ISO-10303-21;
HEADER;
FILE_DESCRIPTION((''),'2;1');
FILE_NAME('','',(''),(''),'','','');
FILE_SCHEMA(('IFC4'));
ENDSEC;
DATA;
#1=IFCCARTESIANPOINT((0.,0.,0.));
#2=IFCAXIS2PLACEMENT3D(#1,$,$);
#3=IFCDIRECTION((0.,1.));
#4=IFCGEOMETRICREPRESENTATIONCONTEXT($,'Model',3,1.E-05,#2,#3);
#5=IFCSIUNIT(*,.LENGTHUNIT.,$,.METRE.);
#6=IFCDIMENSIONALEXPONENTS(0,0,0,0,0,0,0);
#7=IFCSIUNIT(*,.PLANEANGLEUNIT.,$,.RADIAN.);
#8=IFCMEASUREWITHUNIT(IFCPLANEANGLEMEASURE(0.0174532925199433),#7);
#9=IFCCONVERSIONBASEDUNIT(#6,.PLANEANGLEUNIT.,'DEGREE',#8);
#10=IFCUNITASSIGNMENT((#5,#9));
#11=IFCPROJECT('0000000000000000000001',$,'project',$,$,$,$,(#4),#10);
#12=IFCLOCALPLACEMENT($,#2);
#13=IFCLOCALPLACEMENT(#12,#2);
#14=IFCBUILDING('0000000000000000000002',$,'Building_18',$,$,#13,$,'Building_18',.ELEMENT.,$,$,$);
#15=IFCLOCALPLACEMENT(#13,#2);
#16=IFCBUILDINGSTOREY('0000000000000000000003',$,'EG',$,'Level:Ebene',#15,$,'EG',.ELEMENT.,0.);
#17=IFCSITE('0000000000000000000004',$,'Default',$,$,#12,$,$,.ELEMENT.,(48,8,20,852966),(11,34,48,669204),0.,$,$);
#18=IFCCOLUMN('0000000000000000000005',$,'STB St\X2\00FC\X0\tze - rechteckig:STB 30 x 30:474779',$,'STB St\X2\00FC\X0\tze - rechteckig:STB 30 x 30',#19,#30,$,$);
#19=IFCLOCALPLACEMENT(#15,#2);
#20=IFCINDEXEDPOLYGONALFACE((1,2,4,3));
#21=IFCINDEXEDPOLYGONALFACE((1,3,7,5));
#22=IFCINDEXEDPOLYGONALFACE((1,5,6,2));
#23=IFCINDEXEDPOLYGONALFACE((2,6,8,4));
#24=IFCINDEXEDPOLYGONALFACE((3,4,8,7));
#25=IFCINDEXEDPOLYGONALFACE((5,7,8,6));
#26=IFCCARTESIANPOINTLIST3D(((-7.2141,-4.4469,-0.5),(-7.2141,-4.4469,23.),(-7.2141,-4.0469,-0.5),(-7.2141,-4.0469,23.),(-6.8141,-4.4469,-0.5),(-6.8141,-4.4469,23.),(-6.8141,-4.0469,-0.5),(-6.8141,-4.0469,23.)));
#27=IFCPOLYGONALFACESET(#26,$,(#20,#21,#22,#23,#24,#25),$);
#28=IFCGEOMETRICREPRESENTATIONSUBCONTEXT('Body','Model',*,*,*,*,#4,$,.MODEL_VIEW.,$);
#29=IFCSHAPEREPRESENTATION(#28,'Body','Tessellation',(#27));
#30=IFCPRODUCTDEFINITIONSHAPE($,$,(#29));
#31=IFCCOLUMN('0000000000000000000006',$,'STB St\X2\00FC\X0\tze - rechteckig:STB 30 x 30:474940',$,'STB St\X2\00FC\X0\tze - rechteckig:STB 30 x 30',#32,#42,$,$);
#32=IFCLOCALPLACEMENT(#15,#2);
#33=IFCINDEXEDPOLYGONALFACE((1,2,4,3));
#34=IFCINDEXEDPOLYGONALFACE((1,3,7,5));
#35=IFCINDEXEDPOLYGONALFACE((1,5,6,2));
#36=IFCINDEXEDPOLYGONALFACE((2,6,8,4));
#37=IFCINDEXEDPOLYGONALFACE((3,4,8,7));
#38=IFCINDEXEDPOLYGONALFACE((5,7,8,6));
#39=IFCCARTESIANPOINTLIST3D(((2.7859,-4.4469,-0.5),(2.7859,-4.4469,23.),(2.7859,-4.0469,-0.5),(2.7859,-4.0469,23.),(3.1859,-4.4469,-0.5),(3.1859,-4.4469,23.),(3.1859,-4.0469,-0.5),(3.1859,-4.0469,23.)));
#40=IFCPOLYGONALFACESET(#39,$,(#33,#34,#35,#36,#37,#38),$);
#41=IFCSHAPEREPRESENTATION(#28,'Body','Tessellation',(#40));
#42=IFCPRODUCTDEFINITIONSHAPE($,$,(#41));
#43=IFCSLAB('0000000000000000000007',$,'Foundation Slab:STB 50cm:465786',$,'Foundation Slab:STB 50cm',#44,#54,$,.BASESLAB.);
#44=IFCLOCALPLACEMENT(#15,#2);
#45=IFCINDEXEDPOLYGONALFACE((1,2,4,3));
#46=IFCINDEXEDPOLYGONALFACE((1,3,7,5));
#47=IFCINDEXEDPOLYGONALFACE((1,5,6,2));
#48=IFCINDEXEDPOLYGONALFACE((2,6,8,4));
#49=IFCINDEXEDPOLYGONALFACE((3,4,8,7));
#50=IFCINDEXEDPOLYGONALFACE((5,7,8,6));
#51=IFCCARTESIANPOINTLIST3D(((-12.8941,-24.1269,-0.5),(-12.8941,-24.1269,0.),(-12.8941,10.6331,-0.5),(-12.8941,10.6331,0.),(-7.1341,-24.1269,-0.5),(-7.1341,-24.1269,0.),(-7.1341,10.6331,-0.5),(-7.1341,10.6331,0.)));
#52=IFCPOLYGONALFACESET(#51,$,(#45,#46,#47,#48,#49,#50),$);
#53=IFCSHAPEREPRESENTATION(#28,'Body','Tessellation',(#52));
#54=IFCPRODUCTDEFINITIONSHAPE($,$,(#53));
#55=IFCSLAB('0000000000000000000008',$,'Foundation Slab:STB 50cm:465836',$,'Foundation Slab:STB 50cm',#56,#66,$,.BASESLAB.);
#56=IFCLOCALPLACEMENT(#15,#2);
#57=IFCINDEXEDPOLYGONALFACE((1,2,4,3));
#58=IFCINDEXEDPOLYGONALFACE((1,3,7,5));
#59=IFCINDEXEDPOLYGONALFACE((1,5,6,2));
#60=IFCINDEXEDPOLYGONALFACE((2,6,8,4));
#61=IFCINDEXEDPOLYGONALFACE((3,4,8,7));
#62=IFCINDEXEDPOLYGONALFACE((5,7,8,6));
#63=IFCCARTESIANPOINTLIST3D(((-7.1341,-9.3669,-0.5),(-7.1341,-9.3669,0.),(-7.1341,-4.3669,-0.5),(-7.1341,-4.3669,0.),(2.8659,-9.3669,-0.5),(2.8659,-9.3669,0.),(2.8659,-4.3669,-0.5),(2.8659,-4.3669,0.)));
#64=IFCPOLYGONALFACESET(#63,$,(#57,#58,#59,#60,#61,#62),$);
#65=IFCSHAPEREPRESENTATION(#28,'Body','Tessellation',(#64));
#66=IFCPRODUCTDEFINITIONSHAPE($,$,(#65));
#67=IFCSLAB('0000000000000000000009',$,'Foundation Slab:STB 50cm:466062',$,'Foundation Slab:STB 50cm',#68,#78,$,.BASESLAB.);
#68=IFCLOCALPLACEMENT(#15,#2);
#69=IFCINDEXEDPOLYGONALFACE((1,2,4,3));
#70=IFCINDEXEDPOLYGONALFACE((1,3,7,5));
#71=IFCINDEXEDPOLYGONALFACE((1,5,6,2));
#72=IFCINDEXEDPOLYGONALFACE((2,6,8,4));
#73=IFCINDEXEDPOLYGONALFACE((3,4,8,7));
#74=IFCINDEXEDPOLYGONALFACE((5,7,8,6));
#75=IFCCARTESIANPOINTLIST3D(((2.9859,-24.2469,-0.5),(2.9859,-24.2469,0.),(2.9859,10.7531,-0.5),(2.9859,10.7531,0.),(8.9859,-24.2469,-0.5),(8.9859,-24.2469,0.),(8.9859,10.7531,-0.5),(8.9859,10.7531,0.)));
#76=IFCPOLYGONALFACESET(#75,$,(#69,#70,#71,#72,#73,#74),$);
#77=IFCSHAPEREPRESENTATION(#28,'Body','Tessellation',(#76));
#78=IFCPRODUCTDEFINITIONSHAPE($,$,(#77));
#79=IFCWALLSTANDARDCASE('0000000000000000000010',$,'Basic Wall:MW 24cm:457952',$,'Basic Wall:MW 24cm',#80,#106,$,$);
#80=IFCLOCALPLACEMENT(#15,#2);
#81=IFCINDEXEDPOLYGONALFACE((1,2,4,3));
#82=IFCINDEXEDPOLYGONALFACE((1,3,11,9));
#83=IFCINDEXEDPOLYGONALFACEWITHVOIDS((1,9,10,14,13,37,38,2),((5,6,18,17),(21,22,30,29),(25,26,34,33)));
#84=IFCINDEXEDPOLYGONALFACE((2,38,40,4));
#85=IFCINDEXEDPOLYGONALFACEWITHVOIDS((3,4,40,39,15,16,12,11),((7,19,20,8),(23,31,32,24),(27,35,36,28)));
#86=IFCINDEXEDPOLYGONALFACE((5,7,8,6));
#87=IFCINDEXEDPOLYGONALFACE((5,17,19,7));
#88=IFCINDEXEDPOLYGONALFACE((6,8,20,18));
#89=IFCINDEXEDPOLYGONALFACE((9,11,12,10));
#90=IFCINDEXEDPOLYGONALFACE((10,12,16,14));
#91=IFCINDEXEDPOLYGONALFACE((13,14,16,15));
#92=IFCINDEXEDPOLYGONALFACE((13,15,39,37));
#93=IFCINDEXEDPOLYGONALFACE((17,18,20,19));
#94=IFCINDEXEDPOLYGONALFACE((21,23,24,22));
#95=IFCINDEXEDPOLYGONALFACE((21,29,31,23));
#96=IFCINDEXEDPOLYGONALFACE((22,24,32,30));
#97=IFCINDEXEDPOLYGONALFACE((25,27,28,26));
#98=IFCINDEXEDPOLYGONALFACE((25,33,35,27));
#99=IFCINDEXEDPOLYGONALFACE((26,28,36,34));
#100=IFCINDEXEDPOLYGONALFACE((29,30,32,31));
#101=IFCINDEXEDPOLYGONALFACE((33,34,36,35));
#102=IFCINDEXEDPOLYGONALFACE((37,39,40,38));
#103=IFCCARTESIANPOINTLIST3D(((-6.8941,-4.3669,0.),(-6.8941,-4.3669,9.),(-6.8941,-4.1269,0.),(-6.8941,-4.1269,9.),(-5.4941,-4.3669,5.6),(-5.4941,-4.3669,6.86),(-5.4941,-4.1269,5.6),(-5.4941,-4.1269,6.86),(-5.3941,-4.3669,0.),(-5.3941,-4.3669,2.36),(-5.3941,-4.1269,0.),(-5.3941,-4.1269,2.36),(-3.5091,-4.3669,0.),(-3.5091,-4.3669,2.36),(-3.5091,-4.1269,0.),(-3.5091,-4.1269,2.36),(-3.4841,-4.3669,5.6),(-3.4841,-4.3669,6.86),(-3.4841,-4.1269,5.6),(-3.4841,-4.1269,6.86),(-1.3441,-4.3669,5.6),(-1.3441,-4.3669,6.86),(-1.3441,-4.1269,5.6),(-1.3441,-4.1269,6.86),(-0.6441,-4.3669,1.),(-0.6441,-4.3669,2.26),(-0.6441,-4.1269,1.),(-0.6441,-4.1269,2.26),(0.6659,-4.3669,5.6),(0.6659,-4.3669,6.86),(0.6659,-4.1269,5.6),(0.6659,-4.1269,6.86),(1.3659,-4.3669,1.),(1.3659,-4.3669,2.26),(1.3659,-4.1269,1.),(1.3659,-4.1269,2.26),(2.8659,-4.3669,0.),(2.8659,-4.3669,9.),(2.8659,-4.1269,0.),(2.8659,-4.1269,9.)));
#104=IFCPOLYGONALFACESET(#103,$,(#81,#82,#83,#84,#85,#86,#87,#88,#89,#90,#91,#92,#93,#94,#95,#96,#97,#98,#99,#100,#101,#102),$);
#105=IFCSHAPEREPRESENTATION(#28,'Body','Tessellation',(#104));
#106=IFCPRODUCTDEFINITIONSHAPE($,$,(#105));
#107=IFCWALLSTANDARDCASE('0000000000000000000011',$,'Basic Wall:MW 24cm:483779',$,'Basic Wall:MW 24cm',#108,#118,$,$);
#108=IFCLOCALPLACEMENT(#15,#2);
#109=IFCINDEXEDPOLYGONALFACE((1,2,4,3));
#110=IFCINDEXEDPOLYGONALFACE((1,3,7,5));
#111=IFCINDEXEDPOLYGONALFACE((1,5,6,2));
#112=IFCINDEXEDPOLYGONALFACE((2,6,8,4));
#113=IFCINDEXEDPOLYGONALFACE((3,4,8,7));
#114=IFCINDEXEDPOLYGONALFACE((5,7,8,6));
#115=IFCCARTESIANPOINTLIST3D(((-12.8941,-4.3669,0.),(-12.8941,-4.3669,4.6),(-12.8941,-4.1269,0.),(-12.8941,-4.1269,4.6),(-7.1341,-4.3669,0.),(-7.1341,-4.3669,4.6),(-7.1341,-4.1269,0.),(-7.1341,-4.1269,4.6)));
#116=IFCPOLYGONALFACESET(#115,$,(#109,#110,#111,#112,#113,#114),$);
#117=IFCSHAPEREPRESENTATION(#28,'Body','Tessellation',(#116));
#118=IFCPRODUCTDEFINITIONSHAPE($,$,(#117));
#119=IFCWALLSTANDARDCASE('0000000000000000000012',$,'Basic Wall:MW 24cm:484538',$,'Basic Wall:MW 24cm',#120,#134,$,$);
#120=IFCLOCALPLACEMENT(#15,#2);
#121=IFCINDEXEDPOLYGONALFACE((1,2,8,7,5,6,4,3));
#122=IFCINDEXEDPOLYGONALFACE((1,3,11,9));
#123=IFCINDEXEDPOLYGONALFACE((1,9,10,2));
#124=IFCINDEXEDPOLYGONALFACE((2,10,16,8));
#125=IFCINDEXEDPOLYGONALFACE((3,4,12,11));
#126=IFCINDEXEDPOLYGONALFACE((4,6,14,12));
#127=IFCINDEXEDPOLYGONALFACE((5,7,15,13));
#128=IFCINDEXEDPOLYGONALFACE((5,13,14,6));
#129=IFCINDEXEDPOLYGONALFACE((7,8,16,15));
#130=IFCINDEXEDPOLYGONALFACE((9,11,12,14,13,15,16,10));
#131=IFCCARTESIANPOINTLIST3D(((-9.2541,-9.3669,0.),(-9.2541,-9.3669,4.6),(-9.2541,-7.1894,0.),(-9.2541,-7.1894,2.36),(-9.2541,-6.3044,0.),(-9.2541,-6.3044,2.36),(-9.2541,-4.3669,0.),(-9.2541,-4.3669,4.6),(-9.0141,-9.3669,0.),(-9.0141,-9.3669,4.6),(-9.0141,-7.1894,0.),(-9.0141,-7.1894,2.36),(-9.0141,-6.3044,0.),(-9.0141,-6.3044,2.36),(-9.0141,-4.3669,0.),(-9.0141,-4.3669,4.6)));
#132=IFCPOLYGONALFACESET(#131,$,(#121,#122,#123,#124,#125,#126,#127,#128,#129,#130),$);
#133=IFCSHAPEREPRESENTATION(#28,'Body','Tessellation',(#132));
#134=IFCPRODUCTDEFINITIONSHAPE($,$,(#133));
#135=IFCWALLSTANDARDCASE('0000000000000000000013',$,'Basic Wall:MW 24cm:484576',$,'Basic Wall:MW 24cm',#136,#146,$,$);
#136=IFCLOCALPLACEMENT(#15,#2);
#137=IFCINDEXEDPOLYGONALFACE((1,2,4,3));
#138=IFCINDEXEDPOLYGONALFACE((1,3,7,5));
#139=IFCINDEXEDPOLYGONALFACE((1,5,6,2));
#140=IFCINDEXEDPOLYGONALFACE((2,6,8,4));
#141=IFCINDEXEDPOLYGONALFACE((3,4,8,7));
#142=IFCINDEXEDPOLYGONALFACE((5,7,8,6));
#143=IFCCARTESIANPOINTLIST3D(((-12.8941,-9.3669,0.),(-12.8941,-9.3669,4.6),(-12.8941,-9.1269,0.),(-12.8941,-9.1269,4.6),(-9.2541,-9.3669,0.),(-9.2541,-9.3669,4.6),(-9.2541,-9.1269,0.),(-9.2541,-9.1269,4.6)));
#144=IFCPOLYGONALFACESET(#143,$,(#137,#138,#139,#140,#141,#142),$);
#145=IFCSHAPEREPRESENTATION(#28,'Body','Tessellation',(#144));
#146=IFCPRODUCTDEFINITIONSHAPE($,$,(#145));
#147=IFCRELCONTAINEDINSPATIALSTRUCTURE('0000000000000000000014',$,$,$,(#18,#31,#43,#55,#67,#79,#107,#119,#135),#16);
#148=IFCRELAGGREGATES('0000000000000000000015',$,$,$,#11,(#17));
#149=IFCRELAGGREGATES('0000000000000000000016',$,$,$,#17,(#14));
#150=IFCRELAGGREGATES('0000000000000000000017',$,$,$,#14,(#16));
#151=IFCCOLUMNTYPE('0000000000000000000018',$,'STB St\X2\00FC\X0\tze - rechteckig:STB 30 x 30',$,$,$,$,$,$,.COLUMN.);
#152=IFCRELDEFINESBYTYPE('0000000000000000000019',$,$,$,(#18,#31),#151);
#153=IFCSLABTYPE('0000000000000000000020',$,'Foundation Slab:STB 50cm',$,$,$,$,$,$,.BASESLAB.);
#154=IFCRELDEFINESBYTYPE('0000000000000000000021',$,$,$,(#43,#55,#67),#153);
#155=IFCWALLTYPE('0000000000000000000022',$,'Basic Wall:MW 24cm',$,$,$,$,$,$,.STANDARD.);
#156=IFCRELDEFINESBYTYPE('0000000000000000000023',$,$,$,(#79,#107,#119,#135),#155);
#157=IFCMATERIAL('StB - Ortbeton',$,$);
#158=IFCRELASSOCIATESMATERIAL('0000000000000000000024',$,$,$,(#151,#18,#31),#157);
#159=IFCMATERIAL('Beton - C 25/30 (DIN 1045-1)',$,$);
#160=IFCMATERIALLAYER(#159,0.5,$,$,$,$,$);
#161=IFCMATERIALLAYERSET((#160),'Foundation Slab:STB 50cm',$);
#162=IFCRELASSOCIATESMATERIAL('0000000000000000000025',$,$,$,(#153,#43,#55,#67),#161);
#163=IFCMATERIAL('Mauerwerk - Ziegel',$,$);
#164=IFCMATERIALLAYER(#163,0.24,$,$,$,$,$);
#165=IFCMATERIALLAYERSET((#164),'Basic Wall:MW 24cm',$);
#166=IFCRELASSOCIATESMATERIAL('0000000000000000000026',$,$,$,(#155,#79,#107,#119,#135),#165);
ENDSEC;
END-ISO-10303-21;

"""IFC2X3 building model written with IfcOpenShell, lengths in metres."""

from ifc_helpers import new_model, entity, si_unit, converted_unit, direction, frame, frame_2d, origin, origin_2d_with_axis, place, context, subcontext, project, spatial, polyline, rectangle, extrude, clip, bounded_halfspace, source, transform, mapped, material, layer, layer_set, layer_usage, type_object, type_shapes, element, save


model = new_model("IFC2X3")

# Units and contexts
model_context = context("Model", 3, precision=1e-05, world=origin(), true_north=direction((0.0, 1.0)))
body_context = subcontext(model_context, "Body", "Model", "MODEL_VIEW")
ifc_project = project(units=[si_unit("LENGTHUNIT", "METRE"), converted_unit("PLANEANGLEUNIT", "DEGREE", entity("IfcPlaneAngleMeasure", 0.0174532925199433), si_unit("PLANEANGLEUNIT", "RADIAN"), dimensions=[0, 0, 0, 0, 0, 0, 0])], contexts=[model_context])

# Site, building, storey
site_placement = place(None, origin())
site = spatial("IfcSite", under=ifc_project, at=site_placement, Name="Default", CompositionType="ELEMENT", RefLatitude=(48, 8, 20, 852966), RefLongitude=(11, 34, 48, 669204), RefElevation=0.0)
building_placement = place(site_placement, origin())
building = spatial("IfcBuilding", under=site, at=building_placement, Name="Building_18", LongName="Building_18", CompositionType="ELEMENT")
storey_placement = place(building_placement, origin())
storey = spatial("IfcBuildingStorey", under=building, at=storey_placement, Name="EG", ObjectType="Level:Ebene", LongName="EG", CompositionType="ELEMENT", Elevation=0.0)

# Columns
ifc_material_1 = material(Name="StB - Ortbeton")
column_type = type_object("IfcColumnType", Name="STB Stütze - rechteckig:STB 30 x 30", PredefinedType="COLUMN", material=ifc_material_1)
shared_shape_1 = source(origin(), body_context, "Body", "SweptSolid", [
    extrude(rectangle(XDim=0.4, YDim=0.4, at=origin_2d_with_axis()), frame((0.0, 0.0, -0.5), z_axis=(0.0, 0.0, 1.0), x_axis=(-1.0, 0.0, 0.0)), (0.0, 0.0, 1.0), 23.5),
])
type_shapes(column_type, [shared_shape_1])
for number, where, name in (
    (1, (-7.0141, -4.2469, 0.0), "STB Stütze - rechteckig:STB 30 x 30:474779"),
    (2, (2.9859, -4.2469, 0.0), "STB Stütze - rechteckig:STB 30 x 30:474940"),
):
    element("IfcColumn", number, at=place(storey_placement, frame(where)), inside=storey, type_object=column_type, material=ifc_material_1, Name=name, ObjectType="STB Stütze - rechteckig:STB 30 x 30", context=body_context, shape_type="MappedRepresentation", body=[
        mapped(shared_shape_1, transform((0.0, 0.0, 0.0), scale=1.0)),
    ])

# Slabs
ifc_material_2 = material(Name="Beton - C 25/30 (DIN 1045-1)")
ifc_layer_1 = layer(ifc_material_2, 0.5)
ifc_layer_set_1 = layer_set([ifc_layer_1], Name="Foundation Slab:STB 50cm")
ifc_layer_usage_1 = layer_usage(ifc_layer_set_1, "AXIS3", "POSITIVE", 0.0)
slab_type = type_object("IfcSlabType", Name="Foundation Slab:STB 50cm", PredefinedType="BASESLAB", material=ifc_layer_set_1)
slab_1_placement = place(storey_placement, origin())
element("IfcSlab", 3, at=slab_1_placement, inside=storey, type_object=slab_type, material=ifc_layer_usage_1, Name="Foundation Slab:STB 50cm:465786", ObjectType="Foundation Slab:STB 50cm", PredefinedType="BASESLAB", context=body_context, shape_type="SweptSolid", body=[
    extrude(rectangle(XDim=34.76, YDim=5.76, at=frame_2d((0.0, 0.0), x_axis=(1.0, 0.0))), frame((-10.0141, -6.7469, 0.0), z_axis=(0.0, 0.0, -1.0), x_axis=(0.0, 1.0, 0.0)), (0.0, 0.0, 1.0), 0.5),
])
ifc_layer_usage_2 = layer_usage(ifc_layer_set_1, "AXIS3", "POSITIVE", 0.0)
slab_2_placement = place(storey_placement, origin())
element("IfcSlab", 4, at=slab_2_placement, inside=storey, type_object=slab_type, material=ifc_layer_usage_2, Name="Foundation Slab:STB 50cm:465836", ObjectType="Foundation Slab:STB 50cm", PredefinedType="BASESLAB", context=body_context, shape_type="SweptSolid", body=[
    extrude(rectangle(XDim=5.0, YDim=10.0, at=frame_2d((0.0, 0.0), x_axis=(1.0, 0.0))), frame((-2.1341, -6.8669, 0.0), z_axis=(0.0, 0.0, -1.0), x_axis=(0.0, 1.0, 0.0)), (0.0, 0.0, 1.0), 0.5),
])
ifc_layer_usage_3 = layer_usage(ifc_layer_set_1, "AXIS3", "POSITIVE", 0.0)
slab_3_placement = place(storey_placement, origin())
element("IfcSlab", 5, at=slab_3_placement, inside=storey, type_object=slab_type, material=ifc_layer_usage_3, Name="Foundation Slab:STB 50cm:466062", ObjectType="Foundation Slab:STB 50cm", PredefinedType="BASESLAB", context=body_context, shape_type="SweptSolid", body=[
    extrude(rectangle(XDim=35.0, YDim=6.0, at=frame_2d((0.0, 0.0), x_axis=(1.0, 0.0))), frame((5.9859, -6.7469, 0.0), z_axis=(0.0, 0.0, -1.0), x_axis=(0.0, 1.0, 0.0)), (0.0, 0.0, 1.0), 0.5),
])

# Wall, openings
ifc_material_3 = material(Name="Mauerwerk - Ziegel")
ifc_layer_2 = layer(ifc_material_3, 0.24)
ifc_layer_set_2 = layer_set([ifc_layer_2], Name="Basic Wall:MW 24cm")
ifc_layer_usage_4 = layer_usage(ifc_layer_set_2, "AXIS2", "NEGATIVE", 0.12)
wall_type = type_object("IfcWallType", Name="Basic Wall:MW 24cm", PredefinedType="STANDARD", material=ifc_layer_set_2)
wall_1_placement = place(storey_placement, frame((-6.8941, -4.2469, 0.0)))
wall_1 = element("IfcWallStandardCase", 6, at=wall_1_placement, inside=storey, type_object=wall_type, material=ifc_layer_usage_4, Name="Basic Wall:MW 24cm:457952", ObjectType="Basic Wall:MW 24cm", context=body_context, shape_type="Clipping", body=[
    clip(extrude(rectangle(XDim=9.76, YDim=0.24, at=frame_2d((4.88, 0.0), x_axis=(1.0, 0.0))), origin(), (0.0, 0.0, 1.0), 9.0), bounded_halfspace(frame((0.0, -0.12, 9.0), z_axis=(0.0, 0.0, -1.0), x_axis=(0.0, -1.0, 0.0)), True, frame((0.0, -0.12, 9.0)), polyline([(0.0, 0.0), (9.76, 0.0), (9.76, 0.24), (0.0, 0.24), (0.0, 0.0)]))),
])
opening_1_placement = place(wall_1_placement, frame((3.385, 0.12, 0.0)))
element("IfcOpeningElement", 7, at=opening_1_placement, cuts=wall_1, ObjectType="Opening", context=body_context, shape_type="SweptSolid", body=[
    extrude(rectangle(XDim=2.36, YDim=1.885, at=frame_2d((1.18, 0.9425), x_axis=(1.0, 0.0))), frame((0.0, 0.0, 0.0), z_axis=(0.0, -1.0, 0.0), x_axis=(0.0, 0.0, 1.0)), (0.0, 0.0, 1.0), 0.24),
])
opening_2_placement = place(wall_1_placement, frame((6.25, -0.12, 1.0)))
element("IfcOpeningElement", 8, at=opening_2_placement, cuts=wall_1, ObjectType="Opening", context=body_context, shape_type="SweptSolid", body=[
    extrude(rectangle(XDim=1.26, YDim=2.01, at=frame_2d((0.63, 1.005), x_axis=(1.0, 0.0))), frame((0.0, 0.0, 0.0), z_axis=(0.0, 1.0, 0.0), x_axis=(0.0, 0.0, 1.0)), (0.0, 0.0, 1.0), 0.24),
])
opening_3_placement = place(wall_1_placement, frame((7.56, 0.12, 5.6)))
element("IfcOpeningElement", 9, at=opening_3_placement, cuts=wall_1, ObjectType="Opening", context=body_context, shape_type="SweptSolid", body=[
    extrude(rectangle(XDim=1.26, YDim=2.01, at=frame_2d((0.63, 1.005), x_axis=(1.0, 0.0))), frame((0.0, 0.0, 0.0), z_axis=(0.0, -1.0, 0.0), x_axis=(0.0, 0.0, 1.0)), (0.0, 0.0, 1.0), 0.24),
])
opening_4_placement = place(wall_1_placement, frame((3.41, 0.12, 5.6)))
element("IfcOpeningElement", 10, at=opening_4_placement, cuts=wall_1, ObjectType="Opening", context=body_context, shape_type="SweptSolid", body=[
    extrude(rectangle(XDim=1.26, YDim=2.01, at=frame_2d((0.63, 1.005), x_axis=(1.0, 0.0))), frame((0.0, 0.0, 0.0), z_axis=(0.0, -1.0, 0.0), x_axis=(0.0, 0.0, 1.0)), (0.0, 0.0, 1.0), 0.24),
])

# Wall
ifc_layer_usage_5 = layer_usage(ifc_layer_set_2, "AXIS2", "NEGATIVE", 0.12)
wall_2_placement = place(storey_placement, frame((-7.1341, -4.2469, 0.0), z_axis=(0.0, 0.0, 1.0), x_axis=(-1.0, 0.0, 0.0)))
element("IfcWallStandardCase", 11, at=wall_2_placement, inside=storey, type_object=wall_type, material=ifc_layer_usage_5, Name="Basic Wall:MW 24cm:483779", ObjectType="Basic Wall:MW 24cm", context=body_context, shape_type="SweptSolid", body=[
    extrude(rectangle(XDim=5.76, YDim=0.24, at=frame_2d((2.88, 0.0), x_axis=(-1.0, 0.0))), origin(), (0.0, 0.0, 1.0), 4.6),
])

# Wall, opening
ifc_layer_usage_6 = layer_usage(ifc_layer_set_2, "AXIS2", "NEGATIVE", 0.12)
wall_3_placement = place(storey_placement, frame((-9.1341, -4.3669, 0.0), z_axis=(0.0, 0.0, 1.0), x_axis=(0.0, -1.0, 0.0)))
wall_3 = element("IfcWallStandardCase", 12, at=wall_3_placement, inside=storey, type_object=wall_type, material=ifc_layer_usage_6, Name="Basic Wall:MW 24cm:484538", ObjectType="Basic Wall:MW 24cm", context=body_context, shape_type="SweptSolid", body=[
    extrude(rectangle(XDim=5.0, YDim=0.24, at=frame_2d((2.5, 0.0), x_axis=(1.0, 0.0))), origin(), (0.0, 0.0, 1.0), 4.6),
])
opening_5_placement = place(wall_3_placement, frame((2.8225, 0.12, 0.0)))
element("IfcOpeningElement", 13, at=opening_5_placement, cuts=wall_3, ObjectType="Opening", context=body_context, shape_type="SweptSolid", body=[
    extrude(rectangle(XDim=2.36, YDim=0.885, at=frame_2d((1.18, 0.4425), x_axis=(1.0, 0.0))), frame((0.0, 0.0, 0.0), z_axis=(0.0, -1.0, 0.0), x_axis=(0.0, 0.0, 1.0)), (0.0, 0.0, 1.0), 0.24),
])

# Wall
ifc_layer_usage_7 = layer_usage(ifc_layer_set_2, "AXIS2", "NEGATIVE", 0.12)
wall_4_placement = place(storey_placement, frame((-9.2541, -9.2469, 0.0), z_axis=(0.0, 0.0, 1.0), x_axis=(-1.0, 0.0, 0.0)))
element("IfcWallStandardCase", 14, at=wall_4_placement, inside=storey, type_object=wall_type, material=ifc_layer_usage_7, Name="Basic Wall:MW 24cm:484576", ObjectType="Basic Wall:MW 24cm", context=body_context, shape_type="SweptSolid", body=[
    extrude(rectangle(XDim=3.64, YDim=0.24, at=frame_2d((1.82, 0.0), x_axis=(-1.0, 0.0))), origin(), (0.0, 0.0, 1.0), 4.6),
])

save(model, "model.ifc")
